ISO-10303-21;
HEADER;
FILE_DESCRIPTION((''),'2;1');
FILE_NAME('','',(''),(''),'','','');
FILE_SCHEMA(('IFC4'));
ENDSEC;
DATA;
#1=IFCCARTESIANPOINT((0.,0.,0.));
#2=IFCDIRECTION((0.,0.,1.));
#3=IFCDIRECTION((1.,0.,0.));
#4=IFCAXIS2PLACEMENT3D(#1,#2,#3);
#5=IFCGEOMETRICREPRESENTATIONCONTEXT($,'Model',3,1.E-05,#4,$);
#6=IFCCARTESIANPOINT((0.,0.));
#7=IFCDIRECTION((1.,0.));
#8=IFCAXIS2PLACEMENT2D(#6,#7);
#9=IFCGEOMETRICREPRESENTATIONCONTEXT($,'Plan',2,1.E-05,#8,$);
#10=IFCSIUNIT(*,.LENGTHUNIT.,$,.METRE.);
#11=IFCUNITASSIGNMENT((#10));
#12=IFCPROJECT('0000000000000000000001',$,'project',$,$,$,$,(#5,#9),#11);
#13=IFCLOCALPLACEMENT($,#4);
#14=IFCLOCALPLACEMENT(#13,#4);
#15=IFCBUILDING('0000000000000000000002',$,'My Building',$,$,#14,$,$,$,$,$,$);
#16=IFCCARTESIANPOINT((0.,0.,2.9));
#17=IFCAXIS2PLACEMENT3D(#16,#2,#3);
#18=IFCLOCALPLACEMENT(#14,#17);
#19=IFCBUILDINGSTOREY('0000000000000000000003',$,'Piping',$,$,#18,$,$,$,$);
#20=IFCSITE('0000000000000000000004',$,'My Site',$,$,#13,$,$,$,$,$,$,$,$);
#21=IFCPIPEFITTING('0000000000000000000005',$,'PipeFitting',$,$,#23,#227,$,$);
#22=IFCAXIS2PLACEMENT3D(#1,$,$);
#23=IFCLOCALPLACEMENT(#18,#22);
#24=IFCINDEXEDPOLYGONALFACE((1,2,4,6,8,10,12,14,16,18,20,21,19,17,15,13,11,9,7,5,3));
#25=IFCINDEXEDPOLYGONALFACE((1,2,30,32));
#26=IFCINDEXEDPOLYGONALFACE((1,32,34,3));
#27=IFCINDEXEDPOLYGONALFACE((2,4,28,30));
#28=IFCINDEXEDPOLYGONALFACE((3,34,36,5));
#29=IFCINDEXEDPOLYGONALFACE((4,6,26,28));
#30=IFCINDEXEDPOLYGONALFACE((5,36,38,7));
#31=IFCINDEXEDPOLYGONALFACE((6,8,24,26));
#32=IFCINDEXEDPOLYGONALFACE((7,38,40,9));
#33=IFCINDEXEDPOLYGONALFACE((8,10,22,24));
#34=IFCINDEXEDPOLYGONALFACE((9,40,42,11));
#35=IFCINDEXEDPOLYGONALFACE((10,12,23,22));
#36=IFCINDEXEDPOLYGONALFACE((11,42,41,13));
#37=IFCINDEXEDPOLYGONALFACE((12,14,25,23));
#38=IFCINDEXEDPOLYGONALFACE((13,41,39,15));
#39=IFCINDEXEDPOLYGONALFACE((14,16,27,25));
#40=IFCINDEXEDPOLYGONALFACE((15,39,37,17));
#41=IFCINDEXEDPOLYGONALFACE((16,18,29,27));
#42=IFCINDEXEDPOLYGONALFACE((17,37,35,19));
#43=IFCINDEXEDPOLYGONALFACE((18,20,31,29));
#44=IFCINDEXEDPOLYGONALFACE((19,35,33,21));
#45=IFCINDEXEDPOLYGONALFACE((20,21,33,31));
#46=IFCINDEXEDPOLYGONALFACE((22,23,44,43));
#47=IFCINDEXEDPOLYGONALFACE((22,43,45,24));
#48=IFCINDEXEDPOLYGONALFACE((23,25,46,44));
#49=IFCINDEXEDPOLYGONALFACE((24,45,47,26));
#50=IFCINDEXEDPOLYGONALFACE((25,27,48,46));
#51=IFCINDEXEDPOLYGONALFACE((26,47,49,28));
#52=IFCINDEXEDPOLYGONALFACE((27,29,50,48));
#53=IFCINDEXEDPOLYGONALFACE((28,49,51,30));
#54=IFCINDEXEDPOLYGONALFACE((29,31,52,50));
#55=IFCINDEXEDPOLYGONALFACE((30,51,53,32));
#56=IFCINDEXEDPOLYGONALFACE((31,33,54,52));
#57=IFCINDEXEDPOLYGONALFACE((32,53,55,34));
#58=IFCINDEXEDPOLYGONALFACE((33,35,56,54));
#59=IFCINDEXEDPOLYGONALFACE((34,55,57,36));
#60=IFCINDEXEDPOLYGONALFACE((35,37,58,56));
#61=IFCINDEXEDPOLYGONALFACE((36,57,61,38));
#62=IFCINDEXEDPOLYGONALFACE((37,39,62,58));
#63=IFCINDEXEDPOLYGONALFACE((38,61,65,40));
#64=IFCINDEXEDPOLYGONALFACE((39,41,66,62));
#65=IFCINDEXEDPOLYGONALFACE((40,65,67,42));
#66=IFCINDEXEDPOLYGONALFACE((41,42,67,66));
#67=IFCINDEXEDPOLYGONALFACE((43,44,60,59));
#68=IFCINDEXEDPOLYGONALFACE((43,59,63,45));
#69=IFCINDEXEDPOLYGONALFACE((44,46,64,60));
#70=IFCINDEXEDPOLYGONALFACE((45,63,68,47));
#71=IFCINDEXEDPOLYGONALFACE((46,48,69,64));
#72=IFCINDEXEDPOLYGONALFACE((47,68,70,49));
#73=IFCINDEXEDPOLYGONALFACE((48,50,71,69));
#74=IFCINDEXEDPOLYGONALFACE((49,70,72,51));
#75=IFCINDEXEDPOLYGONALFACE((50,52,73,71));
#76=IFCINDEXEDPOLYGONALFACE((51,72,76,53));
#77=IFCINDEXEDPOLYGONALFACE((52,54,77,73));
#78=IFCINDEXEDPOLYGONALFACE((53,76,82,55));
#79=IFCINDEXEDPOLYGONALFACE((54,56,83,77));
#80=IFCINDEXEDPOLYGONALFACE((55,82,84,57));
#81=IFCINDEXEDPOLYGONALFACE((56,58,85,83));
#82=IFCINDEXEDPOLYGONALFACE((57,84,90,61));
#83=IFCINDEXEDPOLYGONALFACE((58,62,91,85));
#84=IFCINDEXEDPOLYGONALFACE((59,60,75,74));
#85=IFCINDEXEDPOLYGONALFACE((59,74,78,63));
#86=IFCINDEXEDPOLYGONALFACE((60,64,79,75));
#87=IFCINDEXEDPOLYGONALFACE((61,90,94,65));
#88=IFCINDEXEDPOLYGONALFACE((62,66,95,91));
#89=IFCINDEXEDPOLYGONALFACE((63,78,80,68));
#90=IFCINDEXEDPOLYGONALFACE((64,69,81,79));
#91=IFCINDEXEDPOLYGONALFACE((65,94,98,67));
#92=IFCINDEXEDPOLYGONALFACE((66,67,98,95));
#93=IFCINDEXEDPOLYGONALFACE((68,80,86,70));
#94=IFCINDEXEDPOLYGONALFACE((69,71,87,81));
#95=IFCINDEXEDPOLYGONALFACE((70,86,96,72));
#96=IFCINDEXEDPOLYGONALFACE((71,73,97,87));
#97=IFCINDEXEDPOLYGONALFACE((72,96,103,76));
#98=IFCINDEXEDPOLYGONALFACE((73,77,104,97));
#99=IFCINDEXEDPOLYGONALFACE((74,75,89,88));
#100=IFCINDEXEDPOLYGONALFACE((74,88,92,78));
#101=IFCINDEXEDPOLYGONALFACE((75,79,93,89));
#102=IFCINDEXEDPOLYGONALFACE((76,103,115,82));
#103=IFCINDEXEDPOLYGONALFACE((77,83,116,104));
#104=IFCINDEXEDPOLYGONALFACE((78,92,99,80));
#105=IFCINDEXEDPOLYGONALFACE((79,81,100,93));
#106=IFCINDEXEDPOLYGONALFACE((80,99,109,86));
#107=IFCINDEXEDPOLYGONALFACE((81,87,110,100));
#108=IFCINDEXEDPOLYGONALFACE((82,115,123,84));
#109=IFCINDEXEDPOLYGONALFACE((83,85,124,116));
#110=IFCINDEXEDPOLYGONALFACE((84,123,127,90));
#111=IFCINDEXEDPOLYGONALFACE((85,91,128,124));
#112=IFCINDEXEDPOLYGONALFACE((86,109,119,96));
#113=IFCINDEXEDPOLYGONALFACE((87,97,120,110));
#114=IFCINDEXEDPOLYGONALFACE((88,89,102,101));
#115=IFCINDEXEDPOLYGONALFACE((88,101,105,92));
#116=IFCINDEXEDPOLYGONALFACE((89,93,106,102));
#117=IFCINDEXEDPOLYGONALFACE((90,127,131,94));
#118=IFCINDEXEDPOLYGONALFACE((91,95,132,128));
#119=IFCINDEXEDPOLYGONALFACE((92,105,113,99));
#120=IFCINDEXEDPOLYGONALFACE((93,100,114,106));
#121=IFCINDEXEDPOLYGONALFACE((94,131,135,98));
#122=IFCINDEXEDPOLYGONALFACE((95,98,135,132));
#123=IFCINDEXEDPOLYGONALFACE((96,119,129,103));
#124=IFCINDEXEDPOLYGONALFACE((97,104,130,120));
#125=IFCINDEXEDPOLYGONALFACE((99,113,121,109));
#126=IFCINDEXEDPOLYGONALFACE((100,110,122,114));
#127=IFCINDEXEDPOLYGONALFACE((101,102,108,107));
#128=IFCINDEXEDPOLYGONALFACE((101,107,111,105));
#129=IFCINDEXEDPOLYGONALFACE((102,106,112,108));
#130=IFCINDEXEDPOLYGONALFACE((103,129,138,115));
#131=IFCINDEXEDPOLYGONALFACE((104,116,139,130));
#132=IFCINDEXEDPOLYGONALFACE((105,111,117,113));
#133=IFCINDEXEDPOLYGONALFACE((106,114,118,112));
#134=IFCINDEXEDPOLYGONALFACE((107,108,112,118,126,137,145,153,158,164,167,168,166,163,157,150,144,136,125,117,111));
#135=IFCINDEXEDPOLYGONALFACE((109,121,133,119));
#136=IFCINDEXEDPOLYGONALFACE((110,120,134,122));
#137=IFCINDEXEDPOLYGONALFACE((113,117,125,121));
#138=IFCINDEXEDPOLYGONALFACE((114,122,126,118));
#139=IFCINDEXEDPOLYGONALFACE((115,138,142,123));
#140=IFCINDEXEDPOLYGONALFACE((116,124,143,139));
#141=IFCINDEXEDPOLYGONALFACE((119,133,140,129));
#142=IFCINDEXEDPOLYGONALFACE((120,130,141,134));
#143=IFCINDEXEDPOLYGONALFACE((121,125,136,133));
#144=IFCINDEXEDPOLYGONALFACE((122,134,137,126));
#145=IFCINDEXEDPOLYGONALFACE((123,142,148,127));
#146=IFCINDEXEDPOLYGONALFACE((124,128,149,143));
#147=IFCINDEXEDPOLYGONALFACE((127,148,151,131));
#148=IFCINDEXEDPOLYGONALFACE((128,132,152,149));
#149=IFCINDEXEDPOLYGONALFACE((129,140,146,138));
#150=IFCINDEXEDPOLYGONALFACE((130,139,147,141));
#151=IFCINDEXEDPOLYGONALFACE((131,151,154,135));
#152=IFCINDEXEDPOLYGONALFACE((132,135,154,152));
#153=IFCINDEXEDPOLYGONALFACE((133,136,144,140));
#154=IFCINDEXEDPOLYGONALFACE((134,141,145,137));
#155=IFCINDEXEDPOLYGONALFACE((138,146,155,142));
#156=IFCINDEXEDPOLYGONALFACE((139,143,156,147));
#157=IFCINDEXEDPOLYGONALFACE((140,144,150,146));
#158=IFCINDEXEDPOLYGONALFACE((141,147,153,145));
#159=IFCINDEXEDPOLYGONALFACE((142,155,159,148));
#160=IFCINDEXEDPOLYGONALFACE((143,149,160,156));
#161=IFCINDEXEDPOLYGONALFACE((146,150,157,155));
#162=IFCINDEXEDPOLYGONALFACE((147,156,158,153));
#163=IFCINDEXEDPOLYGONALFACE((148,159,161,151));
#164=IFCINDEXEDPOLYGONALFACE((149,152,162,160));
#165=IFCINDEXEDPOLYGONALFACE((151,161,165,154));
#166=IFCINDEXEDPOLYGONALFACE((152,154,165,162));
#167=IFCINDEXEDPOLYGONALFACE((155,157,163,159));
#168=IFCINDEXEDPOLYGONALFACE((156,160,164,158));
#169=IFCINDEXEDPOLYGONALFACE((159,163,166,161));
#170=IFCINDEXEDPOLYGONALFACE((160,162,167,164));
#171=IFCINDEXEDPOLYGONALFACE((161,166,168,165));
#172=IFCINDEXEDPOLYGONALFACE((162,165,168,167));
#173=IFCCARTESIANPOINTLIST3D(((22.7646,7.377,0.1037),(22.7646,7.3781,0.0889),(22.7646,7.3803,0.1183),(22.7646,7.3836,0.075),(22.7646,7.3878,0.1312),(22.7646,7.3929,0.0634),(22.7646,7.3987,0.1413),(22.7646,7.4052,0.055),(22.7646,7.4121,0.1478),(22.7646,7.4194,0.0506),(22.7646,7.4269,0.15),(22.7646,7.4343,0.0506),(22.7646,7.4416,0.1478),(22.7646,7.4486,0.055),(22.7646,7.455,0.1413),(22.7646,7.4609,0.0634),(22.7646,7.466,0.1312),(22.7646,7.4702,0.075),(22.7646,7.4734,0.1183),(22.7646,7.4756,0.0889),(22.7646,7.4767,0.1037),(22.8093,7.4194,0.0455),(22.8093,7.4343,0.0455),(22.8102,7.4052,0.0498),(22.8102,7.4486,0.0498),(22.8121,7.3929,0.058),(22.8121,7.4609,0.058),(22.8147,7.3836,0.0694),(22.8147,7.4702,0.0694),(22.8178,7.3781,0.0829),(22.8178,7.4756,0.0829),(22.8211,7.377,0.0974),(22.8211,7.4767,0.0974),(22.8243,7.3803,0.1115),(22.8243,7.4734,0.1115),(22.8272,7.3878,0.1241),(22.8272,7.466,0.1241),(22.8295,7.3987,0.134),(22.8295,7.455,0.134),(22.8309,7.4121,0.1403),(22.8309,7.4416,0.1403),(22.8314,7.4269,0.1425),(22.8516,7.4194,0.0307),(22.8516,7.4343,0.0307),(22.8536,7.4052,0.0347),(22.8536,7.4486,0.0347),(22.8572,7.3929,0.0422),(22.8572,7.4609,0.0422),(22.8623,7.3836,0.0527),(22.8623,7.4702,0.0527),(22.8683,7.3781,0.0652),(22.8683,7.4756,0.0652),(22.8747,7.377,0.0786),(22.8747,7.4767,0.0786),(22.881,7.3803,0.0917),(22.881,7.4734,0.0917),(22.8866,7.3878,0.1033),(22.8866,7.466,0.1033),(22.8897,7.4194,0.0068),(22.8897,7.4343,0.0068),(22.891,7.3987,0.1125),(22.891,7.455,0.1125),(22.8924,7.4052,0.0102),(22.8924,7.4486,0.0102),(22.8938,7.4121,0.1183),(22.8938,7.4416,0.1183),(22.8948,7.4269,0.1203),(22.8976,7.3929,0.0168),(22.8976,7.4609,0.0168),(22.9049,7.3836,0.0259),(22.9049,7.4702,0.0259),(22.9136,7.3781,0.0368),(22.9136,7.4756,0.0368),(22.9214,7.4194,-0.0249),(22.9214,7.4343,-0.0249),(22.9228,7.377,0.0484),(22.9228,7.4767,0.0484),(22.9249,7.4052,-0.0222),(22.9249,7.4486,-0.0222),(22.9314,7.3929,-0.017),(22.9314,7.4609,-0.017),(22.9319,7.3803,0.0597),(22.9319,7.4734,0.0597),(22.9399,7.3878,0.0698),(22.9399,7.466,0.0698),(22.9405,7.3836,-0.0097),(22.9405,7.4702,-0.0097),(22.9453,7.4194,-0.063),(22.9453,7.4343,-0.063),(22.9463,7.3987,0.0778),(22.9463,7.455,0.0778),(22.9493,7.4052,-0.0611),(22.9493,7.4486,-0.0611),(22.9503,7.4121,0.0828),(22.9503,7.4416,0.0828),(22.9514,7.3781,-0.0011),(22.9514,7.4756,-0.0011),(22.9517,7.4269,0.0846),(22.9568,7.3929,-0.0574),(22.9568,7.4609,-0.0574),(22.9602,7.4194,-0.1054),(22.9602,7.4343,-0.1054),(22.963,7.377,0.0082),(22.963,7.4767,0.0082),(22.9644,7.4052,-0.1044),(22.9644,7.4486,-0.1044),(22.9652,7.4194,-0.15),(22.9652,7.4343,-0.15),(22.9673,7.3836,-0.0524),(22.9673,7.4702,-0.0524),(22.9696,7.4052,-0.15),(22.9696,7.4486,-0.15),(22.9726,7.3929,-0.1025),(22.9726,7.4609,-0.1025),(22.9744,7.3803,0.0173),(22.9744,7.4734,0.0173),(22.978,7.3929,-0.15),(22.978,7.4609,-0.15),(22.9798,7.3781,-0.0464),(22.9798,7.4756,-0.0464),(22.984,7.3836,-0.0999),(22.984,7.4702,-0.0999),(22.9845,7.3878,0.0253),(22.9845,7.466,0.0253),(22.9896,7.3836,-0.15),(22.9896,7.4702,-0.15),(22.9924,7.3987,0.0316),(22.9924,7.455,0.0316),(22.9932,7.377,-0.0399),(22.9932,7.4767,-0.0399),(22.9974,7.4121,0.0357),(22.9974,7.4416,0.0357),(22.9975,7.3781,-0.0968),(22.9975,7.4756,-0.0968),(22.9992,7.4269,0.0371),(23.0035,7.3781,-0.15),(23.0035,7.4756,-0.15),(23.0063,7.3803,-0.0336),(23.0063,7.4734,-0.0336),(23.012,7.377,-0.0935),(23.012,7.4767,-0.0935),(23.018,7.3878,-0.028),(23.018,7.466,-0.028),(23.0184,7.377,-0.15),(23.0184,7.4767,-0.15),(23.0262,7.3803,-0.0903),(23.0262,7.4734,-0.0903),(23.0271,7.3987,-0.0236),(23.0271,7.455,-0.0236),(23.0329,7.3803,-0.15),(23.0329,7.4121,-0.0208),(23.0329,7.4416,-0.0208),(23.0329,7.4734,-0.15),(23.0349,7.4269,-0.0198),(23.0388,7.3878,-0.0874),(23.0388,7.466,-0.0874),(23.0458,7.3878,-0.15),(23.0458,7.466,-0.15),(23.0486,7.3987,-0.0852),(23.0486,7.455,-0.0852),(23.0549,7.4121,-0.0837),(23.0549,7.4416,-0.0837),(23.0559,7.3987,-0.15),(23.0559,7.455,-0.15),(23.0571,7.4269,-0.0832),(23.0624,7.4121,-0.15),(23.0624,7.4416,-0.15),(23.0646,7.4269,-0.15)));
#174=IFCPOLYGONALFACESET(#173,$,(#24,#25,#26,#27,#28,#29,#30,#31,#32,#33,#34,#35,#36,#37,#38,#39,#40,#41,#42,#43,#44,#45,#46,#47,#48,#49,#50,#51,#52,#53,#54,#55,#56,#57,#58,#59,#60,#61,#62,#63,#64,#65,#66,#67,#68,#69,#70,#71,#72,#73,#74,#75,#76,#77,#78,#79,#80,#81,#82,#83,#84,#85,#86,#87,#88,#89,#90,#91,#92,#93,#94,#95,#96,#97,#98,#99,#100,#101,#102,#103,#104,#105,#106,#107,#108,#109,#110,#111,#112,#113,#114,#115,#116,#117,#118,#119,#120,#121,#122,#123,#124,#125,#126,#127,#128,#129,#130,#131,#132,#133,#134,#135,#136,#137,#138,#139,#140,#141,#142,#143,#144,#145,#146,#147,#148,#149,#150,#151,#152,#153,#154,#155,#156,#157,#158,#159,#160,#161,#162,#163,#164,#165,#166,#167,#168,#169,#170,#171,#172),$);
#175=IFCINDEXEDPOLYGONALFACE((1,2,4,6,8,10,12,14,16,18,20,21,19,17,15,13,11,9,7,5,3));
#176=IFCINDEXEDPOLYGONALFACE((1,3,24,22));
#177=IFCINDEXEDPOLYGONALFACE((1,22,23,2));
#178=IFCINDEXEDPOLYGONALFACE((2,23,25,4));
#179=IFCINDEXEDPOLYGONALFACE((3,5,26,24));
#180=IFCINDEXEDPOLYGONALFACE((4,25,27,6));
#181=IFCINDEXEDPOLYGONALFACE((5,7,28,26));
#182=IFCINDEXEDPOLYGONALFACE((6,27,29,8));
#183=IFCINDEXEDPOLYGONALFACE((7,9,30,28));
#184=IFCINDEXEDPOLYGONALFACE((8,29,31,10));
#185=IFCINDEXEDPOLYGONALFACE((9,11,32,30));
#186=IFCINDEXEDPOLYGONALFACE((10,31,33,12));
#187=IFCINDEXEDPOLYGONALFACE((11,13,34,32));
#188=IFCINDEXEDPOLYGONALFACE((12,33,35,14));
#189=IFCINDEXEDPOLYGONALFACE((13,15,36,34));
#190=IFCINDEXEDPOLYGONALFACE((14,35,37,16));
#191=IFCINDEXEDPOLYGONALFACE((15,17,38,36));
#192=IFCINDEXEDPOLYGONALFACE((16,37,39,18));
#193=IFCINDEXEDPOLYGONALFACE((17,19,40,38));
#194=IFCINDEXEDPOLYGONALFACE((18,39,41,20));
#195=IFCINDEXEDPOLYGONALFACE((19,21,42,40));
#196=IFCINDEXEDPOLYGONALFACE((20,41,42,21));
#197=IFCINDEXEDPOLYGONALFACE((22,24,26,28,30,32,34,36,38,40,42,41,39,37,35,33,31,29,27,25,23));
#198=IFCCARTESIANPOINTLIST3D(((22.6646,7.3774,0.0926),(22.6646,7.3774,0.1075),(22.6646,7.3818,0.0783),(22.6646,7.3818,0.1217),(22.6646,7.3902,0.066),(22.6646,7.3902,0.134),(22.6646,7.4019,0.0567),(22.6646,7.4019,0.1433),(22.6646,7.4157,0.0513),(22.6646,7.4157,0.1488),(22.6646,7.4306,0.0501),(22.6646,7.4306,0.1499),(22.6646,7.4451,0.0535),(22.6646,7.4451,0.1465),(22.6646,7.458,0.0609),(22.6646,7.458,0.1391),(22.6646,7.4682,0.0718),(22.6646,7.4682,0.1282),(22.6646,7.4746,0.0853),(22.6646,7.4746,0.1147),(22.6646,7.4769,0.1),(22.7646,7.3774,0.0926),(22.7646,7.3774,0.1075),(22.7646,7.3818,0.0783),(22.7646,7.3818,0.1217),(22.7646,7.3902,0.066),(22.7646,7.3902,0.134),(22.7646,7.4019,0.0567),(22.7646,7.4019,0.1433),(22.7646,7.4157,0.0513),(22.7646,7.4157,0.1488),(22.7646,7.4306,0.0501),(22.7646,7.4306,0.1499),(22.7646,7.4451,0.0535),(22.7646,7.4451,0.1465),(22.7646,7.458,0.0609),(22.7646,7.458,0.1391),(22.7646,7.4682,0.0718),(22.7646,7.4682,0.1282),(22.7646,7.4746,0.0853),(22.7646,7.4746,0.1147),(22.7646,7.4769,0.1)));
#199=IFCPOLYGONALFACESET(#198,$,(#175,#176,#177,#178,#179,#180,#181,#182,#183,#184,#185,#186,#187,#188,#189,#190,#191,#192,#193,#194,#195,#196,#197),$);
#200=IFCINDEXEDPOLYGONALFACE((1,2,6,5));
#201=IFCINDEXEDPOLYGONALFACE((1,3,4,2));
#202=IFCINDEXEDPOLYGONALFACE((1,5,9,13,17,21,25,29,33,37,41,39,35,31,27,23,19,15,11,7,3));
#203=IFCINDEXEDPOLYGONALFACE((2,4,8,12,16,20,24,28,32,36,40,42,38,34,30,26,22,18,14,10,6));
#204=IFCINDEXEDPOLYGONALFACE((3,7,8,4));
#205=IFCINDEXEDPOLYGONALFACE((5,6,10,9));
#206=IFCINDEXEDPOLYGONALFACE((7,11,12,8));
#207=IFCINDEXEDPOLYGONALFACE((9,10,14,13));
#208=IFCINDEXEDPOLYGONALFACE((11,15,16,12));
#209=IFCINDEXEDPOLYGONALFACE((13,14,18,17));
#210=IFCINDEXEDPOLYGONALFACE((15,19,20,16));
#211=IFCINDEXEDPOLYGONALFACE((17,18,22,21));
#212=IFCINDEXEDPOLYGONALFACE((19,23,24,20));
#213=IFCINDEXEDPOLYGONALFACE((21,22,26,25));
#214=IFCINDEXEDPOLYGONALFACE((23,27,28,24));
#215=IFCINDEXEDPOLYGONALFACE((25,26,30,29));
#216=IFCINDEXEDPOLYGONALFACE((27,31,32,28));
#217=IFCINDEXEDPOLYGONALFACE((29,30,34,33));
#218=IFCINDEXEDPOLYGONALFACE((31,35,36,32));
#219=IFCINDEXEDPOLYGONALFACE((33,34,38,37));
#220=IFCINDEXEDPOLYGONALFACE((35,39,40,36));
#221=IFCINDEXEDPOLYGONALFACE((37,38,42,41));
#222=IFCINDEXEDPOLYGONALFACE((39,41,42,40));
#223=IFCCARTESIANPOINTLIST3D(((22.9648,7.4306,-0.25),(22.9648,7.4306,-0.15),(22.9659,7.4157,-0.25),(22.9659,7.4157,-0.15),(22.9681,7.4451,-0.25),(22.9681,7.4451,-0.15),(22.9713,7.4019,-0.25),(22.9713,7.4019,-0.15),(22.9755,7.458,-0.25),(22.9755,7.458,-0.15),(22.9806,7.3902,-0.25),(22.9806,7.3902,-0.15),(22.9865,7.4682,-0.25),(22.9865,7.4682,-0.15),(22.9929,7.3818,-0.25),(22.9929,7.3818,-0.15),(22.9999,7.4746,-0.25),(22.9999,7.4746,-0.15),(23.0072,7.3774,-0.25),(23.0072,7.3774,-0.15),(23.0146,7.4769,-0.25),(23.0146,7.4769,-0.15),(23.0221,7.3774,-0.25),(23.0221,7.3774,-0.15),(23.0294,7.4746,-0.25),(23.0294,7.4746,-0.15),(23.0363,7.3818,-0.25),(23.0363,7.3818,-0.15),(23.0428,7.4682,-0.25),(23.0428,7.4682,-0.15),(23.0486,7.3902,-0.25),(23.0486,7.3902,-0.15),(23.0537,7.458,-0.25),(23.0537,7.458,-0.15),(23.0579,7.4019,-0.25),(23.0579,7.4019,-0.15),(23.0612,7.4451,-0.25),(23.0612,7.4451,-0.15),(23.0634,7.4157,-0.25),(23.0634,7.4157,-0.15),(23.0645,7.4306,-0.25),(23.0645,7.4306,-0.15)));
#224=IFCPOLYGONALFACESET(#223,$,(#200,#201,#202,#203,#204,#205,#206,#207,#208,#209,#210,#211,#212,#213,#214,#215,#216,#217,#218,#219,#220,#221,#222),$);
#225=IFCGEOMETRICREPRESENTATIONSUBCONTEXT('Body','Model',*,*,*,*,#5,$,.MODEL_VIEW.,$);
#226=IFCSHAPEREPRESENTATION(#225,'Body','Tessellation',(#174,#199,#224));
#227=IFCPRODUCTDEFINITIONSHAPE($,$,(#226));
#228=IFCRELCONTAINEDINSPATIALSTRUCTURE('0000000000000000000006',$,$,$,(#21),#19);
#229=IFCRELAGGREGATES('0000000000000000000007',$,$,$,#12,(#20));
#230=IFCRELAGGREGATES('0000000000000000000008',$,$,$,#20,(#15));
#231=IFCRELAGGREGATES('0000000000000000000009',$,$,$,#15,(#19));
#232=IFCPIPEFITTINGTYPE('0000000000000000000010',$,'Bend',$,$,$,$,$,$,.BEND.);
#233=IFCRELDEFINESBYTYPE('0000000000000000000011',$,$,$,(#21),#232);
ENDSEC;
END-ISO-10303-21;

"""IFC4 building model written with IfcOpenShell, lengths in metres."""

from ifc_helpers import new_model, entity, si_unit, frame, origin_with_axes, origin_2d_with_axis, place, context, subcontext, project, spatial, circle, extrude, source, transform, mapped, type_object, type_shapes, element, save


model = new_model("IFC4")

# Units and contexts
model_context = context("Model", 3, precision=1e-05, world=origin_with_axes())
plan_context = context("Plan", 2, precision=1e-05, world=origin_2d_with_axis())
body_context = subcontext(model_context, "Body", "Model", "MODEL_VIEW")
ifc_project = project(units=[si_unit("LENGTHUNIT", "METRE")], contexts=[model_context, plan_context])

# Site, building, storey
site_placement = place(None, origin_with_axes())
site = spatial("IfcSite", under=ifc_project, at=site_placement, Name="My Site")
building_placement = place(site_placement, origin_with_axes())
building = spatial("IfcBuilding", under=site, at=building_placement, Name="My Building")
storey_placement = place(building_placement, frame((0.0, 0.0, 2.9), z_axis=(0.0, 0.0, 1.0), x_axis=(1.0, 0.0, 0.0)))
storey = spatial("IfcBuildingStorey", under=building, at=storey_placement, Name="Piping")

# Pipe fitting
pipe_fitting_type = type_object("IfcPipeFittingType", Name="Bend", PredefinedType="BEND")
shared_shape = source(origin_with_axes(), body_context, "Body", "SolidModel", [
    entity("IfcSweptDiskSolid", entity("IfcIndexedPolyCurve", entity("IfcCartesianPointList3D", [[0.0, 0.0, 0.1], [0.0, -0.0732, 0.2768], [0.0, -0.25, 0.35]]), [entity("IfcArcIndex", [1, 2, 3])]), 0.05),
    extrude(circle(Radius=0.05), origin_with_axes(), (0.0, 0.0, 1.0), 0.1),
    extrude(circle(Radius=0.05), frame((0.0, -0.25, 0.35), z_axis=(0.0, -1.0, -0.000001), x_axis=(1.0, 0.0, 0.0)), (0.0, 0.0, 1.0), 0.1),
])
type_shapes(pipe_fitting_type, [shared_shape])
for number, where, z_axis, x_axis, name in (
    (1, (22.6646, 7.4269, 0.1), (1.0, -0.000001, 0.000001), (0.000001, 1.0, 0.0), "PipeFitting"),
):
    element("IfcPipeFitting", number, at=place(storey_placement, frame(where, z_axis=z_axis, x_axis=x_axis)), inside=storey, type_object=pipe_fitting_type, Name=name, context=body_context, shape_type="MappedRepresentation", body=[
        mapped(shared_shape, transform((0.0, 0.0, 0.0), x_axis=(1.0, 0.0, 0.0), y_axis=(0.0, 1.0, 0.0), z_axis=(0.0, 0.0, 1.0), scale=1.0)),
    ])

save(model, "model.ifc")
